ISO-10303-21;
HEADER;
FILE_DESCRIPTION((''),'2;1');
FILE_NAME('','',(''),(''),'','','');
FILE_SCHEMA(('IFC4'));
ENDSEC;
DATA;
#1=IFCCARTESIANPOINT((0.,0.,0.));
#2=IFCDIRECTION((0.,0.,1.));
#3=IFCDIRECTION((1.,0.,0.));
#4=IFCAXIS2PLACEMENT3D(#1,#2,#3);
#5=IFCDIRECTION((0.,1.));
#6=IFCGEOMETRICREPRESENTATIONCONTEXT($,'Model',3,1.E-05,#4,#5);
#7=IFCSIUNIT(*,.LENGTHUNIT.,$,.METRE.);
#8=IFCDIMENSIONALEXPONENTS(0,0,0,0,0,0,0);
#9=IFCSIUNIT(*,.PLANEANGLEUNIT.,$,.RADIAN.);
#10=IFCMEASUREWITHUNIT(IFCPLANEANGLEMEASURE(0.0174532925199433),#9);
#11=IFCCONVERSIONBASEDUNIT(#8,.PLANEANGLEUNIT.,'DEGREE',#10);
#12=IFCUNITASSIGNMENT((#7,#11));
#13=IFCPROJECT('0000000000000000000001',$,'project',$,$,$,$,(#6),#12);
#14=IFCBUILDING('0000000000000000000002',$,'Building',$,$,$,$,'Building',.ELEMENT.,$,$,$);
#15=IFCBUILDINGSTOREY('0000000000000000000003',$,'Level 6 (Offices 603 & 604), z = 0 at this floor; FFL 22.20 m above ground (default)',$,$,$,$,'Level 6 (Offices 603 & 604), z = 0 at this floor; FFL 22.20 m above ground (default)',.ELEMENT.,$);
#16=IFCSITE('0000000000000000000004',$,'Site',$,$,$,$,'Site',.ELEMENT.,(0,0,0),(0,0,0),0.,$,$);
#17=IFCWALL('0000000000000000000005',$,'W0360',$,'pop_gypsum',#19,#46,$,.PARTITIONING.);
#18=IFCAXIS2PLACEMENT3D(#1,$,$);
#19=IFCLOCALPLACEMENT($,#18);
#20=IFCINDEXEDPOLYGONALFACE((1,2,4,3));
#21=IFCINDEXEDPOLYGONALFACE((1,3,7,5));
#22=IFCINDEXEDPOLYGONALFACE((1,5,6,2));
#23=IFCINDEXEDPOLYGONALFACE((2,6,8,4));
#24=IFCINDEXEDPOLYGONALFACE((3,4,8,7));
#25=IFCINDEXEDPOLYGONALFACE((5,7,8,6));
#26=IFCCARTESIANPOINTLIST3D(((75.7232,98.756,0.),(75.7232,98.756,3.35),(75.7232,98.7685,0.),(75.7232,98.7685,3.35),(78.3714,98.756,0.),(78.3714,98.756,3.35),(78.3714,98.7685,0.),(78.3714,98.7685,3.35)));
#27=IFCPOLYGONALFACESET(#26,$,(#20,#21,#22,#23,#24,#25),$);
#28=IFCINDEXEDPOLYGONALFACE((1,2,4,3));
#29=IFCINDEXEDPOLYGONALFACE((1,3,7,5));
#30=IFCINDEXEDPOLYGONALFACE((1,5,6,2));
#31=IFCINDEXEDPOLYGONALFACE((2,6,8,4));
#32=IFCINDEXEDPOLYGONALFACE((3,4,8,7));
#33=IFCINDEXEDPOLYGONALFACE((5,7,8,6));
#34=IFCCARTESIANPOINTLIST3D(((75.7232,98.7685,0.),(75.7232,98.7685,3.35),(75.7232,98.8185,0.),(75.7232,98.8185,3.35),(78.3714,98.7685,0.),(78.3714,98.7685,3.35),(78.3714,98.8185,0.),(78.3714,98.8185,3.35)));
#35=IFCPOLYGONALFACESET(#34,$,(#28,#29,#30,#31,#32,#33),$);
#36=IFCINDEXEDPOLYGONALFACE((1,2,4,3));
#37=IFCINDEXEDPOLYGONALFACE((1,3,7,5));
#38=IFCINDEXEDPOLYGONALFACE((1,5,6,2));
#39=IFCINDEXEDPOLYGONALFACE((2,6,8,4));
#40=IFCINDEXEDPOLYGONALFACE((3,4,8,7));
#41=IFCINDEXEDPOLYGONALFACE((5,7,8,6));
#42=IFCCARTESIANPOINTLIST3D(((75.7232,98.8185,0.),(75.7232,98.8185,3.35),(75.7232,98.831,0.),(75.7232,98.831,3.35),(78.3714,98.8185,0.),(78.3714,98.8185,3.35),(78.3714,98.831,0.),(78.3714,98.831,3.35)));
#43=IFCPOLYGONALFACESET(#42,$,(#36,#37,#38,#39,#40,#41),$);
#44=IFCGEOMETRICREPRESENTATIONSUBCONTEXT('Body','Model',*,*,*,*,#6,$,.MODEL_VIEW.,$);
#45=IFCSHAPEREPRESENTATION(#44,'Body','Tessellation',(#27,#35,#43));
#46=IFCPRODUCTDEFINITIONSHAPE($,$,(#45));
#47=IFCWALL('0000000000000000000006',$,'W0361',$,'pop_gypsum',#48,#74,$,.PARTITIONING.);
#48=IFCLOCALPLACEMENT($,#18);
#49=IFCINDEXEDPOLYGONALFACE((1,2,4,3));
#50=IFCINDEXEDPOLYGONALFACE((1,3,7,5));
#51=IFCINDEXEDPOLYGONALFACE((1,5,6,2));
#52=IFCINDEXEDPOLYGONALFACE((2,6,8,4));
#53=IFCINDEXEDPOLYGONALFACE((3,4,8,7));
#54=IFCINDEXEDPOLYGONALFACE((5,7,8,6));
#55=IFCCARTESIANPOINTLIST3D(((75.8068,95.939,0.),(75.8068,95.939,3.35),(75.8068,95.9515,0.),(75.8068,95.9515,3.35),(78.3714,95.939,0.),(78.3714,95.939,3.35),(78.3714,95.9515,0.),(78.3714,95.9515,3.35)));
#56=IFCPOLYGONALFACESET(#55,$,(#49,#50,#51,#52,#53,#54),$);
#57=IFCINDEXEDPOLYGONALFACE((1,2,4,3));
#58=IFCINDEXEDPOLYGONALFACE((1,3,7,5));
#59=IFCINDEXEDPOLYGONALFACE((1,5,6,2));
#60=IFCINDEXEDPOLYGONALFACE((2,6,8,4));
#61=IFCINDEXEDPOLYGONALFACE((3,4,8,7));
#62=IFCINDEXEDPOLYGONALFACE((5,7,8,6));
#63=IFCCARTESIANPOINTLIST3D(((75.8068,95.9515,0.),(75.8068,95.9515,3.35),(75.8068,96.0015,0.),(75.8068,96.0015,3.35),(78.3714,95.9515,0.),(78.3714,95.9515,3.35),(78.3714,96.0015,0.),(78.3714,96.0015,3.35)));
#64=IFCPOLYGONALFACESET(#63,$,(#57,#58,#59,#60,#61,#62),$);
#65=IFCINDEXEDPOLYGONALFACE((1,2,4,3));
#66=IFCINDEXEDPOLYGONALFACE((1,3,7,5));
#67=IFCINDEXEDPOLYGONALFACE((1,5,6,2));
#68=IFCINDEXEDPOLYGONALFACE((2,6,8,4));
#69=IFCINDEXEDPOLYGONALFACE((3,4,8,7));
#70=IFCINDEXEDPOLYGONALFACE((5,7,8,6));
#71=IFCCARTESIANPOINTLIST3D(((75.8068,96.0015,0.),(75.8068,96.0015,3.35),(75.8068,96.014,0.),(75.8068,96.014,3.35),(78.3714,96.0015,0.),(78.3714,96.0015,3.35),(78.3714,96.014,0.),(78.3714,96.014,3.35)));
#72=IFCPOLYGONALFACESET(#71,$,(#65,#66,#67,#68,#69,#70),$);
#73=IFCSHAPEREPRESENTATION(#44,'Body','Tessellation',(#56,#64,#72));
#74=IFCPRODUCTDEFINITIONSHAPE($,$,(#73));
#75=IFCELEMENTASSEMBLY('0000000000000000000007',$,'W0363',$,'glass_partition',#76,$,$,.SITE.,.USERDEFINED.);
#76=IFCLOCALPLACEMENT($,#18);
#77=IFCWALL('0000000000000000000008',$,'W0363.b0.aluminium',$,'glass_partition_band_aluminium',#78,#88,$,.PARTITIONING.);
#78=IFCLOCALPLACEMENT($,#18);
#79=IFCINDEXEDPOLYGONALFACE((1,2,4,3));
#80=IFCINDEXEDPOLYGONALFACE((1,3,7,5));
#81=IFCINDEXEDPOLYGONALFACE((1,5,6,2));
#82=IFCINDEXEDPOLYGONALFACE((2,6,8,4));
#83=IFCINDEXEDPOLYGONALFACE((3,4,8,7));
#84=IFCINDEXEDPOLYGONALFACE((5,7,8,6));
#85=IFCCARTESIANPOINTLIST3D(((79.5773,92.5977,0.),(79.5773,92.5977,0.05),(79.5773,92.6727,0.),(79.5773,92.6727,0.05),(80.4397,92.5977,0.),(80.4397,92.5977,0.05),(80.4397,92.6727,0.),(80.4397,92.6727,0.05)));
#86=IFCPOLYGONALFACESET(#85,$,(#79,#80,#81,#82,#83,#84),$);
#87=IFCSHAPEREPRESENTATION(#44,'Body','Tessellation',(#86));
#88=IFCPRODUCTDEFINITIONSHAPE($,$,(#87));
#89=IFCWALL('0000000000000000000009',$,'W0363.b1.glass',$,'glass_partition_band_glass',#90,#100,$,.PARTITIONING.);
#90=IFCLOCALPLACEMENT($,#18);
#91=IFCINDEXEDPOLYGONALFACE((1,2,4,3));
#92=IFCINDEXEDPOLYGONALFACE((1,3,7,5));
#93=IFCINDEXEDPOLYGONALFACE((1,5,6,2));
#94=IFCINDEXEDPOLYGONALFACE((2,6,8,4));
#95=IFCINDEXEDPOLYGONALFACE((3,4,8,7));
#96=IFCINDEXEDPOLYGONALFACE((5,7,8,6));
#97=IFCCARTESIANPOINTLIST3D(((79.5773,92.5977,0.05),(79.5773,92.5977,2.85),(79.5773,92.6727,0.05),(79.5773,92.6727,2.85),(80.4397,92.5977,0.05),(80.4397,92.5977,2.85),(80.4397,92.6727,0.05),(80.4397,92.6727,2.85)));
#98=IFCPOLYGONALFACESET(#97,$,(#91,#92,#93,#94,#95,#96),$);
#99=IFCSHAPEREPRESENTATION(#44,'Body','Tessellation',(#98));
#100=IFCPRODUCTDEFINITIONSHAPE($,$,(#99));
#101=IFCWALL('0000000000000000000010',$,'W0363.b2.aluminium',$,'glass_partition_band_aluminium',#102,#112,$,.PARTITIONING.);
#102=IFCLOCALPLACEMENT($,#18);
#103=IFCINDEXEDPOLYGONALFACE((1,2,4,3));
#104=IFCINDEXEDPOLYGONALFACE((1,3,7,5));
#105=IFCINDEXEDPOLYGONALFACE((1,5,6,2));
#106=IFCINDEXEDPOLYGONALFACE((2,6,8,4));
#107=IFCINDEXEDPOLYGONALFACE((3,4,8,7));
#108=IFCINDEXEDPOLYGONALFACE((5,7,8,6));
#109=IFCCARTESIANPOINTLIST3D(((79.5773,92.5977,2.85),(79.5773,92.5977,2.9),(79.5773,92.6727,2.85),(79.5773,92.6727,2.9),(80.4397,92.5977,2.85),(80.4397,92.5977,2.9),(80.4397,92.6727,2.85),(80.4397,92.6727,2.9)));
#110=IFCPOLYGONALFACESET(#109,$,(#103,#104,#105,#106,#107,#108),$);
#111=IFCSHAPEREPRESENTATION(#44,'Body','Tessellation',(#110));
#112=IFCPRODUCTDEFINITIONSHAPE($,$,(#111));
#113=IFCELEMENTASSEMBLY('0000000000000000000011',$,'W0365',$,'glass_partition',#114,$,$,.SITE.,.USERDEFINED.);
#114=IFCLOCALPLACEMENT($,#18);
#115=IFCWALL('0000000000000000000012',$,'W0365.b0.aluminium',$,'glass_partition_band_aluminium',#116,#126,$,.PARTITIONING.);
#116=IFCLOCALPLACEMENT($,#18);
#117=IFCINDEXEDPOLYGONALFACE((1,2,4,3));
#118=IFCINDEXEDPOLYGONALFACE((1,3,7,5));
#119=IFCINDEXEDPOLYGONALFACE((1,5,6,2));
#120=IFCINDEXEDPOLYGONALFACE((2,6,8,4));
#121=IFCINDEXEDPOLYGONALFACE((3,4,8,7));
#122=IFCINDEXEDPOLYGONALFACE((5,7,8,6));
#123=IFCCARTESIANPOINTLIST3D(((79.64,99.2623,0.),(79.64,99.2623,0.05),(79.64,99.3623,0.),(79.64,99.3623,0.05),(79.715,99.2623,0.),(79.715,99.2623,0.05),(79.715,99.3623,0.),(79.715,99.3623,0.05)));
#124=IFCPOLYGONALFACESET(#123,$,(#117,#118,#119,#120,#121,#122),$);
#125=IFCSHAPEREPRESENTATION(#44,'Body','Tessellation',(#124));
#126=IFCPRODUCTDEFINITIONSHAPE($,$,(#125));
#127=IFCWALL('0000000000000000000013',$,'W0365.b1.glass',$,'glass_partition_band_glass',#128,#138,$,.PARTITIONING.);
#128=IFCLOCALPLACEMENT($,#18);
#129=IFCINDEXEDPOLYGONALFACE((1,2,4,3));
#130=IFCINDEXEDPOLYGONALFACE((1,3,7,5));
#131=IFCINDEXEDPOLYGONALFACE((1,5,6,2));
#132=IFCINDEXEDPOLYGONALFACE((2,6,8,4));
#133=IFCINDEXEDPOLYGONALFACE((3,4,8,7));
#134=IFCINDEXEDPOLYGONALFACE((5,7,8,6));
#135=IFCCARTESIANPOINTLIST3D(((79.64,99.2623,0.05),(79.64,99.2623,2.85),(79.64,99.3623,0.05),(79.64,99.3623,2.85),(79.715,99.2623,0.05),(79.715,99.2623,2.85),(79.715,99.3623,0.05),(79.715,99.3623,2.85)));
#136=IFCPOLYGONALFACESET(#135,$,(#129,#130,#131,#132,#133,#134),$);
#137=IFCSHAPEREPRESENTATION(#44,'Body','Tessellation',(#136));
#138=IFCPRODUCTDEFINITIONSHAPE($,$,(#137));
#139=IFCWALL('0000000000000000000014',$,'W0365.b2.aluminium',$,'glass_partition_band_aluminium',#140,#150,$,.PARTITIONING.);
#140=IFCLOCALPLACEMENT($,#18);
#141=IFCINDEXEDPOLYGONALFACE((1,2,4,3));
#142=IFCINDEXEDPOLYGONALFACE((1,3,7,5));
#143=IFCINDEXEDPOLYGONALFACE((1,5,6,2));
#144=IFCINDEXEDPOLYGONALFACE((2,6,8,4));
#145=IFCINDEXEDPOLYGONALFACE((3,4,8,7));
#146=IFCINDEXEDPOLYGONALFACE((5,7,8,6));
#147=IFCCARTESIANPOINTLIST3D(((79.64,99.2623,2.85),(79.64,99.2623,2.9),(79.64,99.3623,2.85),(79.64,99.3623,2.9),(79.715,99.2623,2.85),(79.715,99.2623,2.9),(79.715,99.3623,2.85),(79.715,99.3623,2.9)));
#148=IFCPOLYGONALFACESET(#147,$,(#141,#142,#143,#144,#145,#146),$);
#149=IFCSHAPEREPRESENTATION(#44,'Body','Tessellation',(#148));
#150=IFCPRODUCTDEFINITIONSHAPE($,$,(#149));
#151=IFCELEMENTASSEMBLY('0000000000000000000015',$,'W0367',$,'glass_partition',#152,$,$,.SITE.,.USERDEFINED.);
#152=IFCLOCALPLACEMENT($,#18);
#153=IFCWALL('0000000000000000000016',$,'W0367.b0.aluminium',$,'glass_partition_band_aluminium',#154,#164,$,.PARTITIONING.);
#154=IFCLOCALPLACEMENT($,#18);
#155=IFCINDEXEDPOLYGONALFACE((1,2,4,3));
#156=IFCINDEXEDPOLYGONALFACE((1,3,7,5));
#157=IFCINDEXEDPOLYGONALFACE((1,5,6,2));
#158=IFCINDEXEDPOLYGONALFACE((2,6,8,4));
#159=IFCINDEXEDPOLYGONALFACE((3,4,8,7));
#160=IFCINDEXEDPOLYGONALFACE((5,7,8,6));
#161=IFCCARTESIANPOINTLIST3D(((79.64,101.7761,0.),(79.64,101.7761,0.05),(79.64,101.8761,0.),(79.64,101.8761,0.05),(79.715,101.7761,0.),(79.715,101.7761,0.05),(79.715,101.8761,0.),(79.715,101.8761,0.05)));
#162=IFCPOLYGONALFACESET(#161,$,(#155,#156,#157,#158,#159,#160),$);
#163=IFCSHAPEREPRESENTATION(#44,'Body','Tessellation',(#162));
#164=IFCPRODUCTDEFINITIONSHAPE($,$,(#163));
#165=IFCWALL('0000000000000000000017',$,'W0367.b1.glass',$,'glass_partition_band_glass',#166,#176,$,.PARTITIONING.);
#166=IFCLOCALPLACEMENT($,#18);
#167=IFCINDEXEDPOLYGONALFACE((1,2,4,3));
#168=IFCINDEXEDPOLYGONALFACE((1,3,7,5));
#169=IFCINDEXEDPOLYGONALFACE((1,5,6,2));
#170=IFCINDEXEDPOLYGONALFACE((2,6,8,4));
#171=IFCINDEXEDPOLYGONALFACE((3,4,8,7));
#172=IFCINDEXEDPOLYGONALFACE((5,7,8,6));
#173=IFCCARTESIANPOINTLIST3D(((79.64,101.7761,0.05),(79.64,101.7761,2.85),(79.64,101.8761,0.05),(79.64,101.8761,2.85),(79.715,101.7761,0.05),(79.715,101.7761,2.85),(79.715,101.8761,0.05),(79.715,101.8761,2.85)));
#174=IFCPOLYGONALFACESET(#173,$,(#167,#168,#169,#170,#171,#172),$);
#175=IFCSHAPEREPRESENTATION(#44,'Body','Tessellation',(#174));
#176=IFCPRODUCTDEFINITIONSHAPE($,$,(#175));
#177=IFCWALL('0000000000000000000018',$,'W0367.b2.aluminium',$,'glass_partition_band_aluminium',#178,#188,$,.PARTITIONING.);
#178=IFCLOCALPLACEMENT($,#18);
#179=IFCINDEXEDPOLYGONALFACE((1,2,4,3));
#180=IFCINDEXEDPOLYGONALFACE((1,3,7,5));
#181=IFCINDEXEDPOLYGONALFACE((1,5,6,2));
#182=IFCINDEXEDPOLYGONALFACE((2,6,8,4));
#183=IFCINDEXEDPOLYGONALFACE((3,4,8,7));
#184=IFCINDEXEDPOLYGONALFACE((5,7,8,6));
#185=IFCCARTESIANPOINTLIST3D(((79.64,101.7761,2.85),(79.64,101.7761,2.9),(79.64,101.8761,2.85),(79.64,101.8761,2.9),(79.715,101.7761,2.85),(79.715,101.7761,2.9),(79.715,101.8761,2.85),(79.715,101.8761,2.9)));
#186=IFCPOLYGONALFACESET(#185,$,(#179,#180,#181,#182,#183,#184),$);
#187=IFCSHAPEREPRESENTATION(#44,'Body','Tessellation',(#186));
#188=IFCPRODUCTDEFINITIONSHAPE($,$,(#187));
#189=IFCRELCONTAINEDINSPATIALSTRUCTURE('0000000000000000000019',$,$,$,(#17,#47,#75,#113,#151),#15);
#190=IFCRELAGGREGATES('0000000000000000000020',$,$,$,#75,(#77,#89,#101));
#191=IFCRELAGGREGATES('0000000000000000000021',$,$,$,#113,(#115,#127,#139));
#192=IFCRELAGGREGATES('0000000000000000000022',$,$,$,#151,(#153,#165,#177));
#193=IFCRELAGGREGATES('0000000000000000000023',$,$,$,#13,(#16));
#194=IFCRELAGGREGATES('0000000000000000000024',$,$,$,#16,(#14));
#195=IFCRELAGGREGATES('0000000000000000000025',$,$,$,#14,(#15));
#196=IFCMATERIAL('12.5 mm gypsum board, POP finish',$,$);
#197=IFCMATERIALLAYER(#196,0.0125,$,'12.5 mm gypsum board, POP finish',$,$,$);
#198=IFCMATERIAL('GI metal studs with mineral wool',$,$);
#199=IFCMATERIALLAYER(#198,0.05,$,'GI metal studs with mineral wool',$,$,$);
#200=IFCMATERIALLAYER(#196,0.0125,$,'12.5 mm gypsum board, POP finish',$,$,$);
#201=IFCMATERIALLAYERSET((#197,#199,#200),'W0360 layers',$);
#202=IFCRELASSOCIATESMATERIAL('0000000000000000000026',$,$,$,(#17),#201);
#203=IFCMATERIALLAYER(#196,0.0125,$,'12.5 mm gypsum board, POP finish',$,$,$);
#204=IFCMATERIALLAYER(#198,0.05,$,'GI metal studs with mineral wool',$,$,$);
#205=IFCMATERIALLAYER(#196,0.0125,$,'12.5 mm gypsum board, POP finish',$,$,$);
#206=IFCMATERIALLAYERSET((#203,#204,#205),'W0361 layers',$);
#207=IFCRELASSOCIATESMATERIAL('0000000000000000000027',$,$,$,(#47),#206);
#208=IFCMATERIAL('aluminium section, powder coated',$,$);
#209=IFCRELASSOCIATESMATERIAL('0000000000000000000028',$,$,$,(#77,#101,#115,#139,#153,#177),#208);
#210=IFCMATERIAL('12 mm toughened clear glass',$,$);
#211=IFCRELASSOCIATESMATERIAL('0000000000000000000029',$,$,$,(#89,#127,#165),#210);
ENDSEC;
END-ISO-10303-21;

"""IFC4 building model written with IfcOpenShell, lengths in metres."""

from ifc_helpers import new_model, entity, si_unit, converted_unit, direction, frame, frame_2d, origin_with_axes, place, context, subcontext, project, spatial, rectangle, extrude, material, layer, layer_set, layer_usage, element, aggregate, save


model = new_model("IFC4")

# Units and contexts
model_context = context("Model", 3, precision=1e-05, world=origin_with_axes(), true_north=direction((0.0, 1.0)))
body_context = subcontext(model_context, "Body", "Model", "MODEL_VIEW")
ifc_project = project(units=[si_unit("LENGTHUNIT", "METRE"), converted_unit("PLANEANGLEUNIT", "DEGREE", entity("IfcPlaneAngleMeasure", 0.0174532925199433), si_unit("PLANEANGLEUNIT", "RADIAN"), dimensions=[0, 0, 0, 0, 0, 0, 0])], contexts=[model_context])

# Site, building, storey
site = spatial("IfcSite", under=ifc_project, Name="Site", LongName="Site", CompositionType="ELEMENT", RefLatitude=(0, 0, 0), RefLongitude=(0, 0, 0), RefElevation=0.0)
building = spatial("IfcBuilding", under=site, Name="Building", LongName="Building", CompositionType="ELEMENT")
storey = spatial("IfcBuildingStorey", under=building, Name="Level 6 (Offices 603 & 604), z = 0 at this floor; FFL 22.20 m above ground (default)", LongName="Level 6 (Offices 603 & 604), z = 0 at this floor; FFL 22.20 m above ground (default)", CompositionType="ELEMENT")

# Shared definitions
ifc_material_1 = material(Name="aluminium section, powder coated")
placement = place(None, origin_with_axes())

# Shared definitions
ifc_material_2 = material(Name="12 mm toughened clear glass")

# Walls
ifc_material_3 = material(Name="12.5 mm gypsum board, POP finish")
ifc_material_4 = material(Name="GI metal studs with mineral wool")
ifc_layer_1 = layer(ifc_material_3, 0.0125, Name="12.5 mm gypsum board, POP finish")
ifc_layer_2 = layer(ifc_material_4, 0.05, Name="GI metal studs with mineral wool")
ifc_layer_3 = layer(ifc_material_3, 0.0125, Name="12.5 mm gypsum board, POP finish")
ifc_layer_set_1 = layer_set([ifc_layer_1, ifc_layer_2, ifc_layer_3], Name="W0360 layers")
ifc_layer_usage_1 = layer_usage(ifc_layer_set_1, "AXIS2", "POSITIVE", -0.0375)
element("IfcWall", 1, at=placement, inside=storey, material=ifc_layer_usage_1, Name="W0360", ObjectType="pop_gypsum", PredefinedType="PARTITIONING", context=body_context, shape_type="SweptSolid", body=[
    extrude(rectangle(XDim=2.6482, YDim=0.0125, at=frame_2d((0.0, 0.0), x_axis=(1.0, 0.0))), frame((77.0473, 98.7622, 0.0), z_axis=(0.0, 0.0, 1.0), x_axis=(1.0, 0.0, 0.0)), (0.0, 0.0, 1.0), 3.35),
    extrude(rectangle(XDim=2.6482, YDim=0.05, at=frame_2d((0.0, 0.0313), x_axis=(1.0, 0.0))), frame((77.0473, 98.7622, 0.0), z_axis=(0.0, 0.0, 1.0), x_axis=(1.0, 0.0, 0.0)), (0.0, 0.0, 1.0), 3.35),
    extrude(rectangle(XDim=2.6482, YDim=0.0125, at=frame_2d((0.0, 0.0625), x_axis=(1.0, 0.0))), frame((77.0473, 98.7622, 0.0), z_axis=(0.0, 0.0, 1.0), x_axis=(1.0, 0.0, 0.0)), (0.0, 0.0, 1.0), 3.35),
])
ifc_layer_4 = layer(ifc_material_3, 0.0125, Name="12.5 mm gypsum board, POP finish")
ifc_layer_5 = layer(ifc_material_4, 0.05, Name="GI metal studs with mineral wool")
ifc_layer_6 = layer(ifc_material_3, 0.0125, Name="12.5 mm gypsum board, POP finish")
ifc_layer_set_2 = layer_set([ifc_layer_4, ifc_layer_5, ifc_layer_6], Name="W0361 layers")
ifc_layer_usage_2 = layer_usage(ifc_layer_set_2, "AXIS2", "POSITIVE", -0.0375)
element("IfcWall", 2, at=placement, inside=storey, material=ifc_layer_usage_2, Name="W0361", ObjectType="pop_gypsum", PredefinedType="PARTITIONING", context=body_context, shape_type="SweptSolid", body=[
    extrude(rectangle(XDim=2.5646, YDim=0.0125, at=frame_2d((0.0, 0.0), x_axis=(1.0, 0.0))), frame((77.0891, 95.9453, 0.0), z_axis=(0.0, 0.0, 1.0), x_axis=(1.0, 0.0, 0.0)), (0.0, 0.0, 1.0), 3.35),
    extrude(rectangle(XDim=2.5646, YDim=0.05, at=frame_2d((0.0, 0.0312), x_axis=(1.0, 0.0))), frame((77.0891, 95.9453, 0.0), z_axis=(0.0, 0.0, 1.0), x_axis=(1.0, 0.0, 0.0)), (0.0, 0.0, 1.0), 3.35),
    extrude(rectangle(XDim=2.5646, YDim=0.0125, at=frame_2d((0.0, 0.0625), x_axis=(1.0, 0.0))), frame((77.0891, 95.9453, 0.0), z_axis=(0.0, 0.0, 1.0), x_axis=(1.0, 0.0, 0.0)), (0.0, 0.0, 1.0), 3.35),
])

# Element assemblies, walls
assembly_1 = element("IfcElementAssembly", 3, inside=storey, Name="W0363", ObjectType="glass_partition", AssemblyPlace="SITE", PredefinedType="USERDEFINED")
wall_1 = element("IfcWall", 4, at=placement, material=ifc_material_1, Name="W0363.b0.aluminium", ObjectType="glass_partition_band_aluminium", PredefinedType="PARTITIONING", context=body_context, shape_type="SweptSolid", body=[
    extrude(rectangle(XDim=0.8624, YDim=0.075, at=frame_2d((0.0, 0.0), x_axis=(1.0, 0.0))), frame((80.0085, 92.6352, 0.0), z_axis=(0.0, 0.0, 1.0), x_axis=(1.0, 0.0, 0.0)), (0.0, 0.0, 1.0), 0.05),
])
wall_2 = element("IfcWall", 5, at=placement, material=ifc_material_2, Name="W0363.b1.glass", ObjectType="glass_partition_band_glass", PredefinedType="PARTITIONING", context=body_context, shape_type="SweptSolid", body=[
    extrude(rectangle(XDim=0.8624, YDim=0.075, at=frame_2d((0.0, 0.0), x_axis=(1.0, 0.0))), frame((80.0085, 92.6352, 0.05), z_axis=(0.0, 0.0, 1.0), x_axis=(1.0, 0.0, 0.0)), (0.0, 0.0, 1.0), 2.8),
])
wall_3 = element("IfcWall", 6, at=placement, material=ifc_material_1, Name="W0363.b2.aluminium", ObjectType="glass_partition_band_aluminium", PredefinedType="PARTITIONING", context=body_context, shape_type="SweptSolid", body=[
    extrude(rectangle(XDim=0.8624, YDim=0.075, at=frame_2d((0.0, 0.0), x_axis=(1.0, 0.0))), frame((80.0085, 92.6352, 2.85), z_axis=(0.0, 0.0, 1.0), x_axis=(1.0, 0.0, 0.0)), (0.0, 0.0, 1.0), 0.05),
])
aggregate(assembly_1, [wall_1, wall_2, wall_3])
assembly_2 = element("IfcElementAssembly", 7, inside=storey, Name="W0365", ObjectType="glass_partition", AssemblyPlace="SITE", PredefinedType="USERDEFINED")
wall_4 = element("IfcWall", 8, at=placement, material=ifc_material_1, Name="W0365.b0.aluminium", ObjectType="glass_partition_band_aluminium", PredefinedType="PARTITIONING", context=body_context, shape_type="SweptSolid", body=[
    extrude(rectangle(XDim=0.1, YDim=0.075, at=frame_2d((0.0, 0.0), x_axis=(0.0, 1.0))), frame((79.6775, 99.3123, 0.0), z_axis=(0.0, 0.0, 1.0), x_axis=(1.0, 0.0, 0.0)), (0.0, 0.0, 1.0), 0.05),
])
wall_5 = element("IfcWall", 9, at=placement, material=ifc_material_2, Name="W0365.b1.glass", ObjectType="glass_partition_band_glass", PredefinedType="PARTITIONING", context=body_context, shape_type="SweptSolid", body=[
    extrude(rectangle(XDim=0.1, YDim=0.075, at=frame_2d((0.0, 0.0), x_axis=(0.0, 1.0))), frame((79.6775, 99.3123, 0.05), z_axis=(0.0, 0.0, 1.0), x_axis=(1.0, 0.0, 0.0)), (0.0, 0.0, 1.0), 2.8),
])
wall_6 = element("IfcWall", 10, at=placement, material=ifc_material_1, Name="W0365.b2.aluminium", ObjectType="glass_partition_band_aluminium", PredefinedType="PARTITIONING", context=body_context, shape_type="SweptSolid", body=[
    extrude(rectangle(XDim=0.1, YDim=0.075, at=frame_2d((0.0, 0.0), x_axis=(0.0, 1.0))), frame((79.6775, 99.3123, 2.85), z_axis=(0.0, 0.0, 1.0), x_axis=(1.0, 0.0, 0.0)), (0.0, 0.0, 1.0), 0.05),
])
aggregate(assembly_2, [wall_4, wall_5, wall_6])
assembly_3 = element("IfcElementAssembly", 11, inside=storey, Name="W0367", ObjectType="glass_partition", AssemblyPlace="SITE", PredefinedType="USERDEFINED")
wall_7 = element("IfcWall", 12, at=placement, material=ifc_material_1, Name="W0367.b0.aluminium", ObjectType="glass_partition_band_aluminium", PredefinedType="PARTITIONING", context=body_context, shape_type="SweptSolid", body=[
    extrude(rectangle(XDim=0.1, YDim=0.075, at=frame_2d((0.0, 0.0), x_axis=(0.0, 1.0))), frame((79.6775, 101.8261, 0.0), z_axis=(0.0, 0.0, 1.0), x_axis=(1.0, 0.0, 0.0)), (0.0, 0.0, 1.0), 0.05),
])
wall_8 = element("IfcWall", 13, at=placement, material=ifc_material_2, Name="W0367.b1.glass", ObjectType="glass_partition_band_glass", PredefinedType="PARTITIONING", context=body_context, shape_type="SweptSolid", body=[
    extrude(rectangle(XDim=0.1, YDim=0.075, at=frame_2d((0.0, 0.0), x_axis=(0.0, 1.0))), frame((79.6775, 101.8261, 0.05), z_axis=(0.0, 0.0, 1.0), x_axis=(1.0, 0.0, 0.0)), (0.0, 0.0, 1.0), 2.8),
])
wall_9 = element("IfcWall", 14, at=placement, material=ifc_material_1, Name="W0367.b2.aluminium", ObjectType="glass_partition_band_aluminium", PredefinedType="PARTITIONING", context=body_context, shape_type="SweptSolid", body=[
    extrude(rectangle(XDim=0.1, YDim=0.075, at=frame_2d((0.0, 0.0), x_axis=(0.0, 1.0))), frame((79.6775, 101.8261, 2.85), z_axis=(0.0, 0.0, 1.0), x_axis=(1.0, 0.0, 0.0)), (0.0, 0.0, 1.0), 0.05),
])
aggregate(assembly_3, [wall_7, wall_8, wall_9])

save(model, "model.ifc")
